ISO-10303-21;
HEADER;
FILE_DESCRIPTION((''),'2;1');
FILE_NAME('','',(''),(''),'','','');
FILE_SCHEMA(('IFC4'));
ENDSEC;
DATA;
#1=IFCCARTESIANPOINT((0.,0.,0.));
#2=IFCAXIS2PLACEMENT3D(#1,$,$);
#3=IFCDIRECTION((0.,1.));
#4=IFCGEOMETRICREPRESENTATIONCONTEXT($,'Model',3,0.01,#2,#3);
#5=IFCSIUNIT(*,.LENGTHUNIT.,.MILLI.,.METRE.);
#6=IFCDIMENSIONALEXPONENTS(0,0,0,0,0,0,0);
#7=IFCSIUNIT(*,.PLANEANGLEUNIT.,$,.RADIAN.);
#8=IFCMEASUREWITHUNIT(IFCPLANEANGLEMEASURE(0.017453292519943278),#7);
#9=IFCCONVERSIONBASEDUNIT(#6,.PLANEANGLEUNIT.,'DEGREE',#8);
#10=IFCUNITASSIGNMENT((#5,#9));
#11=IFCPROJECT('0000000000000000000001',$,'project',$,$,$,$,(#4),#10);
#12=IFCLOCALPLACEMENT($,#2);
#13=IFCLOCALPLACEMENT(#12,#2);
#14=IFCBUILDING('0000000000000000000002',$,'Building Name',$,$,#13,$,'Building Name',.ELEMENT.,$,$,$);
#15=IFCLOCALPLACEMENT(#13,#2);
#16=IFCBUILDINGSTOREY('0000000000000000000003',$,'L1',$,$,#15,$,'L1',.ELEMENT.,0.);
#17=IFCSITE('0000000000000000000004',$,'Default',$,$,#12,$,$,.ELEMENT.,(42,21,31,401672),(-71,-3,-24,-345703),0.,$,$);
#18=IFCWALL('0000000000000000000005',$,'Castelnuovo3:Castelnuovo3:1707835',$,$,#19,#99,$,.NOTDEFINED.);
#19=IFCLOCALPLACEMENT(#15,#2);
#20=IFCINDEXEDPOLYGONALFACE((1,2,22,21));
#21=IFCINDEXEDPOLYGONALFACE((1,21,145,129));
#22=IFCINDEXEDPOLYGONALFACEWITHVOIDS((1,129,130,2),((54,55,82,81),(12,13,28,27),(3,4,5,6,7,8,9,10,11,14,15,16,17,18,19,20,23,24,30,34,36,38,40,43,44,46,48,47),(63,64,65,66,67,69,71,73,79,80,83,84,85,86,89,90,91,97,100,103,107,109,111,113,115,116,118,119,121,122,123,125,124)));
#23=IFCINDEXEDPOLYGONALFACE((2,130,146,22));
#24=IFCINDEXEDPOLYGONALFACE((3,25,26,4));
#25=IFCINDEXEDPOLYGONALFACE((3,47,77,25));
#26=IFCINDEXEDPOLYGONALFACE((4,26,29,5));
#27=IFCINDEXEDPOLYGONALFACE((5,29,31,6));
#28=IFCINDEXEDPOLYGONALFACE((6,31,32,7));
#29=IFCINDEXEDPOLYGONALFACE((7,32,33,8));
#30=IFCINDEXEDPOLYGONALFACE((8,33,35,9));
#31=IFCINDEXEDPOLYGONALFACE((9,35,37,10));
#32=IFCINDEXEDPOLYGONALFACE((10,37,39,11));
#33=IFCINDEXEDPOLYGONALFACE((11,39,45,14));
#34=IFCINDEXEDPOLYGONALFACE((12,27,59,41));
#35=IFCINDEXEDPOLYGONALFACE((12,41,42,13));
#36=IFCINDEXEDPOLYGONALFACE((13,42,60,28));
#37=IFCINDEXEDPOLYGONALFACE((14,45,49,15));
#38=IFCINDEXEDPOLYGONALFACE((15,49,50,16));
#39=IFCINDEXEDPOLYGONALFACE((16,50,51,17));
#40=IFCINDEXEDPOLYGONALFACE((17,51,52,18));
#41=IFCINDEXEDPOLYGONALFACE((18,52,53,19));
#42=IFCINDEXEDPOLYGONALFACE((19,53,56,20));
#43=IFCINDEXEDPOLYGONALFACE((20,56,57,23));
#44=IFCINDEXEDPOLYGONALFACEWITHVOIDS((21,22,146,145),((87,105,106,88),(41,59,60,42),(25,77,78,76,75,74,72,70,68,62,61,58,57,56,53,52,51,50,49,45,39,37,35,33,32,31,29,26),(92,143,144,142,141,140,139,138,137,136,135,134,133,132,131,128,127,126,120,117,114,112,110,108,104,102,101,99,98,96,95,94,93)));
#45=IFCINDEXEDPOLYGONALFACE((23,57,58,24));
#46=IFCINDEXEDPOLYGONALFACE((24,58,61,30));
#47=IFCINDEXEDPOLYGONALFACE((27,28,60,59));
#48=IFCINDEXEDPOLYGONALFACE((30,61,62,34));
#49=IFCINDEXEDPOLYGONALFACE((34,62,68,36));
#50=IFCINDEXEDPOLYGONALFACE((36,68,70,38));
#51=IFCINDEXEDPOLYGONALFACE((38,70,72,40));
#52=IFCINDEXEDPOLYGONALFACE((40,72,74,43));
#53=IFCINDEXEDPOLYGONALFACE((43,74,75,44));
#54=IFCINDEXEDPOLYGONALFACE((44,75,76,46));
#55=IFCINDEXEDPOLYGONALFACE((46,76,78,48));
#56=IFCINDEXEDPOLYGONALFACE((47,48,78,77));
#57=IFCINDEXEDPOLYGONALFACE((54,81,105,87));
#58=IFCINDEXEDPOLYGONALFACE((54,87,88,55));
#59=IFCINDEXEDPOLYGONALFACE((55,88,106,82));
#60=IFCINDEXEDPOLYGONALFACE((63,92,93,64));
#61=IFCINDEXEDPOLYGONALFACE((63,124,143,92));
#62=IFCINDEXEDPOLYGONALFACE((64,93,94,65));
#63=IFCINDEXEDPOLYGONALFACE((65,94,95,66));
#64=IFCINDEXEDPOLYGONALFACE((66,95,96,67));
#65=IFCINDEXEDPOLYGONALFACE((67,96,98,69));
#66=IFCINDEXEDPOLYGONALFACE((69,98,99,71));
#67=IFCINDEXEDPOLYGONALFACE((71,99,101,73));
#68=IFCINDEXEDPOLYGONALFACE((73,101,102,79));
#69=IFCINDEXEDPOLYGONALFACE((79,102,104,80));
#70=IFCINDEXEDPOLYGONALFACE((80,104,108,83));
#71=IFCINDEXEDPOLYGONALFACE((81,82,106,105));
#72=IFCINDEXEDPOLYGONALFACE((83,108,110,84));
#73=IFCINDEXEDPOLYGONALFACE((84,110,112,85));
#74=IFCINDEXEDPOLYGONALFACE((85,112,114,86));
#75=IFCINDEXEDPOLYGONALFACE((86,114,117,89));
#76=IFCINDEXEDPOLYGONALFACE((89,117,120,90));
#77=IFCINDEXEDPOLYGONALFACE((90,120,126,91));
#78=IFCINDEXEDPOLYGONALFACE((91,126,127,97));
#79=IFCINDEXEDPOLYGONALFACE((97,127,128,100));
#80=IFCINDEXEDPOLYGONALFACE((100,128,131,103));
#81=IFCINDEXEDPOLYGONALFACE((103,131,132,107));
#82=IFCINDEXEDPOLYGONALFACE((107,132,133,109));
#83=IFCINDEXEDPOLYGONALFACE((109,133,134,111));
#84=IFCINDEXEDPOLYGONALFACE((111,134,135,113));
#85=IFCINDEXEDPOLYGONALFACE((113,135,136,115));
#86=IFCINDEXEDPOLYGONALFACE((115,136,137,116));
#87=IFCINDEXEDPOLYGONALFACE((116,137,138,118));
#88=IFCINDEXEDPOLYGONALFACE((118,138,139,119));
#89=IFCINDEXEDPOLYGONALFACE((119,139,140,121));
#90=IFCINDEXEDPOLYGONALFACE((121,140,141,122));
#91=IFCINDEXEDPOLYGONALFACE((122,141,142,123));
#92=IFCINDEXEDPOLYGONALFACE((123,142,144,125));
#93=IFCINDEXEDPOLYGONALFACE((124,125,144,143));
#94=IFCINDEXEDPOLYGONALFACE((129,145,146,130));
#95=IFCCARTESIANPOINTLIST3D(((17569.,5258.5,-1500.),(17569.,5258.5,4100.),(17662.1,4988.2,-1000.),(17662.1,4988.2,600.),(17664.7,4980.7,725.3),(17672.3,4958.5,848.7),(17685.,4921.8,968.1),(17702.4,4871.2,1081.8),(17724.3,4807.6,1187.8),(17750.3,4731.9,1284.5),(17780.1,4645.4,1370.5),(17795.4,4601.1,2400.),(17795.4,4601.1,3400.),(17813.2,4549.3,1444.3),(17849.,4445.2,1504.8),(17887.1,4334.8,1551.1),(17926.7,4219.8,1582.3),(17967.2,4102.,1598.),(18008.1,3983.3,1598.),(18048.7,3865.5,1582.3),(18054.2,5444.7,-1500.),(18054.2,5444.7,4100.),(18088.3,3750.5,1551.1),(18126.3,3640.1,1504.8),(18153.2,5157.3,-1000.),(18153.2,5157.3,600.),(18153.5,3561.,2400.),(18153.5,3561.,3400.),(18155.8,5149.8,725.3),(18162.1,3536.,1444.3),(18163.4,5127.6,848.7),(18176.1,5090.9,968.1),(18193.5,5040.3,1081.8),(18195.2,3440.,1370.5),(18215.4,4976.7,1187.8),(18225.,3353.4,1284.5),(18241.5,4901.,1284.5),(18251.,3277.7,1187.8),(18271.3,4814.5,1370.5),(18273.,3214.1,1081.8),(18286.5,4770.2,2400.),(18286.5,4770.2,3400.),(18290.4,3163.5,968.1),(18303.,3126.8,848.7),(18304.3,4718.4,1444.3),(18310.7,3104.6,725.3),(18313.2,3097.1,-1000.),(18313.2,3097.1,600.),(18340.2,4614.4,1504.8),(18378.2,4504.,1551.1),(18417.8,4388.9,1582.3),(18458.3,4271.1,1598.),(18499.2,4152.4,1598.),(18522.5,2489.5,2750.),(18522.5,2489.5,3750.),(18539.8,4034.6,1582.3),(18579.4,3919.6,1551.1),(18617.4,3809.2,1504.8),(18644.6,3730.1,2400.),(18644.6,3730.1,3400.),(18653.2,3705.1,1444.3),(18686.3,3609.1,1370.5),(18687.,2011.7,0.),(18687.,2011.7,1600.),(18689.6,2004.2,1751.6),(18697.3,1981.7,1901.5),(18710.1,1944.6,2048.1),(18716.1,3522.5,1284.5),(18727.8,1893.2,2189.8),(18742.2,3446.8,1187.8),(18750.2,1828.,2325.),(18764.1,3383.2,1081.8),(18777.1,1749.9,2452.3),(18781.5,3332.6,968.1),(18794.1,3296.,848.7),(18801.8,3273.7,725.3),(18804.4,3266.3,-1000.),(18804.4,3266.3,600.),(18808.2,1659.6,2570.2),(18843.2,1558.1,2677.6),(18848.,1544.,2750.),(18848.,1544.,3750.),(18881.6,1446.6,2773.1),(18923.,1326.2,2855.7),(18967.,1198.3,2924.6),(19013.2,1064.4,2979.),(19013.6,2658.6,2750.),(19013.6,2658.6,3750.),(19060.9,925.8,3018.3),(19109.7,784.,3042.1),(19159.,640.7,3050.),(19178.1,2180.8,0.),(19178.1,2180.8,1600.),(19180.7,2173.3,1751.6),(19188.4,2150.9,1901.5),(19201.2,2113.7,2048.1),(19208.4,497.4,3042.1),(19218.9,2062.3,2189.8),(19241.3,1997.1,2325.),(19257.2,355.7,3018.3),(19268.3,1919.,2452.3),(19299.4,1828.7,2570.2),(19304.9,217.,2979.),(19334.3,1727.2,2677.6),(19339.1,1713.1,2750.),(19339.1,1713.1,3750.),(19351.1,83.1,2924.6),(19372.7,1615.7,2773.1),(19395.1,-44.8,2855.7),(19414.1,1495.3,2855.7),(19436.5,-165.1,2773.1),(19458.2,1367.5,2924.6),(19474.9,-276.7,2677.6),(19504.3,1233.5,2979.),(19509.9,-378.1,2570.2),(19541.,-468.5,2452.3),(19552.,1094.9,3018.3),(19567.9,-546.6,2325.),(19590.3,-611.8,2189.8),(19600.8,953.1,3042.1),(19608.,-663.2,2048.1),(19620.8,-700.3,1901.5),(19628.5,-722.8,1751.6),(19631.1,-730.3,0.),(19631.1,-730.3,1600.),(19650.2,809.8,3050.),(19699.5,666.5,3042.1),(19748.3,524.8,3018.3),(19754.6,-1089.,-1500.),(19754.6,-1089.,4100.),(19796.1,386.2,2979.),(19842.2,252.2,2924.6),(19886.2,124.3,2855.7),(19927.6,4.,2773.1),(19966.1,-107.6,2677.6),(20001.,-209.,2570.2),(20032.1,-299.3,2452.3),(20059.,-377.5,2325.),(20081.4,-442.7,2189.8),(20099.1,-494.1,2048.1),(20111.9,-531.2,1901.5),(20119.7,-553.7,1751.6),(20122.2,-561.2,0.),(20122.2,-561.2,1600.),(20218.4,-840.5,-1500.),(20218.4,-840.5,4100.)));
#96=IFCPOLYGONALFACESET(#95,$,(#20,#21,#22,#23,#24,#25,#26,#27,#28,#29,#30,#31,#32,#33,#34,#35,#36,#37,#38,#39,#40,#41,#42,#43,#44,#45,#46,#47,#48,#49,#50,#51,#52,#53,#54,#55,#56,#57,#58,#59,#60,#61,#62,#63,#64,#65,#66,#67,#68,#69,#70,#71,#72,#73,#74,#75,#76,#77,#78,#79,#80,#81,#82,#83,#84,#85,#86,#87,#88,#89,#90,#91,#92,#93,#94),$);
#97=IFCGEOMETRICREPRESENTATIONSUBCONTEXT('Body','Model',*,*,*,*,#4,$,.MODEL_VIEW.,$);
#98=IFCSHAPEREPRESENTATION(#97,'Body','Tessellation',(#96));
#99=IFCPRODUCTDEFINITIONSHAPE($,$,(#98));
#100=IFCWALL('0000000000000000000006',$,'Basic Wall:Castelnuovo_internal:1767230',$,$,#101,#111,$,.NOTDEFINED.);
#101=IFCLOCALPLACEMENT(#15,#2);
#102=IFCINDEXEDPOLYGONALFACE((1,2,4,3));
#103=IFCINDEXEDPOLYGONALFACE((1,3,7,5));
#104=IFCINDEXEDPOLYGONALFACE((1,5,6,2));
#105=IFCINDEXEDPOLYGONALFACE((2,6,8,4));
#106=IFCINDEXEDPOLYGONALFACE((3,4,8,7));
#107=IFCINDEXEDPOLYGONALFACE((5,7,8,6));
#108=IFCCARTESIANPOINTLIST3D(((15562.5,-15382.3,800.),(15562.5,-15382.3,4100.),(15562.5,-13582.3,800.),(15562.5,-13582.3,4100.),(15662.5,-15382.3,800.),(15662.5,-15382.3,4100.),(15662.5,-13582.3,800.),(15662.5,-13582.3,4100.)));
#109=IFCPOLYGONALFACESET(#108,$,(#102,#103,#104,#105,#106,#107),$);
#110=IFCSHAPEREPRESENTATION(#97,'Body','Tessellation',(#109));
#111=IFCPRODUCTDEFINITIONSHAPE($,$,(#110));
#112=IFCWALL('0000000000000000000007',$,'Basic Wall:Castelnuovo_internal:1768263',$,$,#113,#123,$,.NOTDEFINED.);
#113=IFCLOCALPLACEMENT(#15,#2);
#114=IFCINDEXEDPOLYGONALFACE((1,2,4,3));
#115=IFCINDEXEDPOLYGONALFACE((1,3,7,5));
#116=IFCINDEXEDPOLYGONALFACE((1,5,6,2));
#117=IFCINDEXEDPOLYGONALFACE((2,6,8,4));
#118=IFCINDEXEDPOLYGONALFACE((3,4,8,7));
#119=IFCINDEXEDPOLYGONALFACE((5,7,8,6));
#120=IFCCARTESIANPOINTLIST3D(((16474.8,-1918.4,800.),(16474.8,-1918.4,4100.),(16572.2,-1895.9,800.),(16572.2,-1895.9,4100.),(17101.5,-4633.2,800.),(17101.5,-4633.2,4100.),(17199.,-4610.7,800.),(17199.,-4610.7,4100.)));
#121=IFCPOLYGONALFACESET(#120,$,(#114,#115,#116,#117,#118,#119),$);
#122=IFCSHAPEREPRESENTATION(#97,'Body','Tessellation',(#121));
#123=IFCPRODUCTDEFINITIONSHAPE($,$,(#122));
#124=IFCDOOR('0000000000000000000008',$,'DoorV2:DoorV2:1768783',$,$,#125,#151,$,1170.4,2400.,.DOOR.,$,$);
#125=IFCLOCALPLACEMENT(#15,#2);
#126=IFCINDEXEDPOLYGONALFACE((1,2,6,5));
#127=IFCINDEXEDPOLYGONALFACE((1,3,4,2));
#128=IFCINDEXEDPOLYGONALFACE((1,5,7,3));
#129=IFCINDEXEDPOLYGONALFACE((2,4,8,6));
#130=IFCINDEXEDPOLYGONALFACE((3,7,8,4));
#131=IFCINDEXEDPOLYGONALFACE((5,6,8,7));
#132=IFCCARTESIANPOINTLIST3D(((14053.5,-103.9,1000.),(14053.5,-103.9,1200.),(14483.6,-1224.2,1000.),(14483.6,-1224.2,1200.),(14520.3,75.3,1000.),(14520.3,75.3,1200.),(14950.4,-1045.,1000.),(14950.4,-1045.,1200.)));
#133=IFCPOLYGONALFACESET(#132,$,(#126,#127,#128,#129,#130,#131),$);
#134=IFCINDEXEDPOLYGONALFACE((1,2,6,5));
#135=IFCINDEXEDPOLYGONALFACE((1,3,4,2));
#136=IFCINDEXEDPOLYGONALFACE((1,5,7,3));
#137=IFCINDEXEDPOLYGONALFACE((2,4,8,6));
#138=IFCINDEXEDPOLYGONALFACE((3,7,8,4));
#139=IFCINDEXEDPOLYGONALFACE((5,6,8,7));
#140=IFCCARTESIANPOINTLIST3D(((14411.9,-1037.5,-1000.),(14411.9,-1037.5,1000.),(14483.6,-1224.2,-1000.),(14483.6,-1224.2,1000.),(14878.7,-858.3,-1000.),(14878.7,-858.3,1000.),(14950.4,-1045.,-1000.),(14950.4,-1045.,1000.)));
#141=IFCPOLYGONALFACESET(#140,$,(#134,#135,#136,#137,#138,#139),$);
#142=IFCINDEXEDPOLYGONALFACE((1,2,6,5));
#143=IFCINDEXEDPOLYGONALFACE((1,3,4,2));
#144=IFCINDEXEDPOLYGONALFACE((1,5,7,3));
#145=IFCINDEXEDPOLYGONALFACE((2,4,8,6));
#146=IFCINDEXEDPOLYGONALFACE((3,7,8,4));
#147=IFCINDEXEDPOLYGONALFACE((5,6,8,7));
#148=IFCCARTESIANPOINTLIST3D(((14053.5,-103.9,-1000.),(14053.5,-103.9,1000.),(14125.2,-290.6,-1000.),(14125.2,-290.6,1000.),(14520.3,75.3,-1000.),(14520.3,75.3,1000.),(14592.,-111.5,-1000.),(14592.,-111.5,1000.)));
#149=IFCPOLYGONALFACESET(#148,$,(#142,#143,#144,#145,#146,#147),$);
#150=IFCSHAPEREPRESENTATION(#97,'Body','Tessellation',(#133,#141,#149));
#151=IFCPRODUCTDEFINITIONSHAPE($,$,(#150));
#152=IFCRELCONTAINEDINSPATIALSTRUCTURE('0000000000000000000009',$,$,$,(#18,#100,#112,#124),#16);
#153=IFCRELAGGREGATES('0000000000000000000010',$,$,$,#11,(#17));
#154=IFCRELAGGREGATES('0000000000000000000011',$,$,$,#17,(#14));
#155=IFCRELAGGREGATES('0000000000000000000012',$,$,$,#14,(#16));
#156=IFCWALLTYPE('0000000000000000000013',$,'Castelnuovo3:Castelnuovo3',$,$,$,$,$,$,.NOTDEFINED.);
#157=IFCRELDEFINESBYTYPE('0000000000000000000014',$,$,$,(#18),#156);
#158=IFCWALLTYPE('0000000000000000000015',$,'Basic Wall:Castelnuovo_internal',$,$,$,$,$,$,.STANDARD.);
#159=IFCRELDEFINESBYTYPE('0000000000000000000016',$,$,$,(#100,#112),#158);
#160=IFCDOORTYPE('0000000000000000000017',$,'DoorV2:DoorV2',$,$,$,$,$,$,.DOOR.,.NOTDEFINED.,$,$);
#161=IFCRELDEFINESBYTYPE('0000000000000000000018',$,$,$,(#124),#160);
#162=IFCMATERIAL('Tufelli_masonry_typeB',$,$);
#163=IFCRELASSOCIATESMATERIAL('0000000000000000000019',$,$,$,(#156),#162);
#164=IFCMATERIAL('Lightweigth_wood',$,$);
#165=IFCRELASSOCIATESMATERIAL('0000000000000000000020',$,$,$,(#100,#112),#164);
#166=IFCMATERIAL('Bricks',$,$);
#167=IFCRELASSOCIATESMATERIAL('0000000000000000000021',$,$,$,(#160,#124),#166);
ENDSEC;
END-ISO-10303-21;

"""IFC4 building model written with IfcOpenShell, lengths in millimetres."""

from ifc_helpers import new_model, entity, si_unit, converted_unit, direction, frame, origin, place, context, subcontext, project, spatial, line, arc, indexed_curve, outline, extrude, source, transform, mapped, material, type_object, type_shapes, element, save


model = new_model("IFC4")

# Units and contexts
model_context = context("Model", 3, precision=0.01, world=origin(), true_north=direction((0.0, 1.0)))
body_context = subcontext(model_context, "Body", "Model", "MODEL_VIEW")
ifc_project = project(units=[si_unit("LENGTHUNIT", "METRE", prefix="MILLI"), converted_unit("PLANEANGLEUNIT", "DEGREE", entity("IfcPlaneAngleMeasure", 0.017453292519943278), si_unit("PLANEANGLEUNIT", "RADIAN"), dimensions=[0, 0, 0, 0, 0, 0, 0])], contexts=[model_context])

# Site, building, storey
site_placement = place(None, origin())
site = spatial("IfcSite", under=ifc_project, at=site_placement, Name="Default", CompositionType="ELEMENT", RefLatitude=(42, 21, 31, 401672), RefLongitude=(-71, -3, -24, -345703), RefElevation=0.0)
building_placement = place(site_placement, origin())
building = spatial("IfcBuilding", under=site, at=building_placement, Name="Building Name", LongName="Building Name", CompositionType="ELEMENT")
storey_placement = place(building_placement, origin())
storey = spatial("IfcBuildingStorey", under=building, at=storey_placement, Name="L1", LongName="L1", CompositionType="ELEMENT", Elevation=0.0)

# Shared definitions
ifc_material_1 = material(Name="Tufelli_masonry_typeB")

# Wall, openings
wall_type_1 = type_object("IfcWallType", Name="Castelnuovo3:Castelnuovo3", PredefinedType="NOTDEFINED", material=ifc_material_1)
wall_1_placement = place(storey_placement, frame((17569.0, -1089.0, -1500.0), z_axis=(0.0, 0.0, 1.0), x_axis=(0.0, 1.0, 0.0)))
wall_1 = element("IfcWall", 1, at=wall_1_placement, inside=storey, type_object=wall_type_1, Name="Castelnuovo3:Castelnuovo3:1707835", PredefinedType="NOTDEFINED", context=body_context, shape_type="SweptSolid", body=[
    extrude(outline(indexed_curve([(-376.4, -3338.1), (143.3, -3338.1), (377.6, 3371.0), (-144.5, 3305.2), (-376.4, -3338.1)], self_intersect=False)), frame((3282.4, -1330.1, 0.0), z_axis=(0.0, 0.0, 1.0), x_axis=(-0.358368, 0.93358, 0.0)), (0.0, 0.0, 1.0), 5600.0),
])
opening_1_placement = place(wall_1_placement, origin())
element("IfcOpeningElement", 2, at=opening_1_placement, cuts=wall_1, PredefinedType="OPENING", context=body_context, shape_type="SweptSolid", body=[
    extrude(outline(indexed_curve([(-500.0, -500.0), (500.0, -500.0), (500.0, 500.0), (-500.0, 500.0), (-500.0, -500.0)], self_intersect=False)), frame((3099.0, -1096.6, 4750.0), z_axis=(0.325568, -0.945519, 0.0), x_axis=(0.0, 0.0, 1.0)), (0.0, 0.0, 1.0), 612.9),
])
opening_2_placement = place(wall_1_placement, origin())
element("IfcOpeningElement", 3, at=opening_2_placement, cuts=wall_1, PredefinedType="OPENING", context=body_context, shape_type="SweptSolid", body=[
    extrude(outline(indexed_curve([(-500.0, -550.0), (500.0, -550.0), (500.0, 550.0), (-500.0, 550.0), (-500.0, -550.0)], self_intersect=False)), frame((5163.3, -385.8, 4400.0), z_axis=(0.325568, -0.945519, 0.0), x_axis=(0.0, 0.0, 1.0)), (0.0, 0.0, 1.0), 612.9),
])
opening_3_placement = place(wall_1_placement, origin())
element("IfcOpeningElement", 4, at=opening_3_placement, cuts=wall_1, PredefinedType="OPENING", context=body_context, shape_type="SweptSolid", body=[
    extrude(outline(indexed_curve([(-800.0, -1000.0), (800.0, -1000.0), (800.0, 1000.0), (-800.0, 1000.0), (-1800.0, 0.0)], segments=[line(1, 2, 3, 4), arc(4, 5, 1)], self_intersect=False)), frame((5124.9, -399.0, 1300.0), z_axis=(0.325568, -0.945519, 0.0), x_axis=(0.0, 0.0, -1.0)), (0.0, 0.0, 1.0), 612.9),
])
opening_4_placement = place(wall_1_placement, origin())
element("IfcOpeningElement", 5, at=opening_4_placement, cuts=wall_1, PredefinedType="OPENING", context=body_context, shape_type="SweptSolid", body=[
    extrude(outline(indexed_curve([(-800.0, -1450.0), (800.0, -1450.0), (800.0, 1450.0), (-800.0, 1450.0), (-2250.0, 0.0)], segments=[line(1, 2, 3, 4), arc(4, 5, 1)], self_intersect=False)), frame((1905.6, -2100.8, 2300.0), z_axis=(-0.325568, 0.945519, 0.0), x_axis=(0.0, 0.0, -1.0)), (0.0, 0.0, 1.0), 612.9),
])

# Walls
ifc_material_2 = material(Name="Lightweigth_wood")
wall_type_2 = type_object("IfcWallType", Name="Basic Wall:Castelnuovo_internal", PredefinedType="STANDARD")
wall_2_placement = place(storey_placement, frame((15612.5, -15382.3, 800.0), z_axis=(0.0, 0.0, 1.0), x_axis=(0.0, 1.0, 0.0)))
element("IfcWall", 6, at=wall_2_placement, inside=storey, type_object=wall_type_2, material=ifc_material_2, Name="Basic Wall:Castelnuovo_internal:1767230", PredefinedType="NOTDEFINED", context=body_context, shape_type="SweptSolid", body=[
    extrude(outline(indexed_curve([(1800.0, 50.0), (0.0, 50.0), (0.0, -50.0), (1800.0, -50.0), (1800.0, 50.0)], self_intersect=False)), origin(), (0.0, 0.0, 1.0), 3300.0),
])
wall_3_placement = place(storey_placement, frame((17150.3, -4621.9, 800.0), z_axis=(0.0, 0.0, 1.0), x_axis=(-0.224951, 0.97437, 0.0)))
element("IfcWall", 7, at=wall_3_placement, inside=storey, type_object=wall_type_2, material=ifc_material_2, Name="Basic Wall:Castelnuovo_internal:1768263", PredefinedType="NOTDEFINED", context=body_context, shape_type="SweptSolid", body=[
    extrude(outline(indexed_curve([(2786.2, 50.0), (0.0, 50.0), (0.0, -50.0), (2786.2, -50.0), (2786.2, 50.0)], self_intersect=False)), origin(), (0.0, 0.0, 1.0), 3300.0),
])

# Door
ifc_material_3 = material(Name="Bricks")
door_type_1 = type_object("IfcDoorType", Name="DoorV2:DoorV2", OperationType="NOTDEFINED", PredefinedType="DOOR", material=ifc_material_3)
shared_shape_1 = source(origin(), body_context, "Body", "SweptSolid", [
    extrude(outline(indexed_curve([(-250.0, -600.0), (250.0, -600.0), (250.0, 600.0), (-250.0, 600.0), (-250.0, -600.0)], self_intersect=False)), frame((0.0, 0.0, 2000.0), z_axis=(0.0, 0.0, 1.0), x_axis=(0.0, 1.0, 0.0)), (0.0, 0.0, 1.0), 200.0),
    extrude(outline(indexed_curve([(-250.0, -100.0), (250.0, -100.0), (250.0, 100.0), (-250.0, 100.0), (-250.0, -100.0)], self_intersect=False)), frame((500.0, 0.0, 0.0), z_axis=(0.0, 0.0, 1.0), x_axis=(0.0, 1.0, 0.0)), (0.0, 0.0, 1.0), 2000.0),
    extrude(outline(indexed_curve([(-250.0, -100.0), (250.0, -100.0), (250.0, 100.0), (-250.0, 100.0), (-250.0, -100.0)], self_intersect=False)), frame((-500.0, 0.0, 0.0), z_axis=(0.0, 0.0, 1.0), x_axis=(0.0, 1.0, 0.0)), (0.0, 0.0, 1.0), 2000.0),
])
type_shapes(door_type_1, [shared_shape_1])
door_1_placement = place(storey_placement, frame((14502.0, -574.5, -1000.0), z_axis=(0.0, 0.0, 1.0), x_axis=(0.358368, -0.93358, 0.0)))
element("IfcDoor", 8, at=door_1_placement, inside=storey, type_object=door_type_1, material=ifc_material_3, Name="DoorV2:DoorV2:1768783", OverallHeight=1170.4, OverallWidth=2400.0, PredefinedType="DOOR", context=body_context, shape_type="MappedRepresentation", body=[
    mapped(shared_shape_1, transform((0.0, 0.0, 0.0), scale=1.0)),
])

save(model, "model.ifc")
